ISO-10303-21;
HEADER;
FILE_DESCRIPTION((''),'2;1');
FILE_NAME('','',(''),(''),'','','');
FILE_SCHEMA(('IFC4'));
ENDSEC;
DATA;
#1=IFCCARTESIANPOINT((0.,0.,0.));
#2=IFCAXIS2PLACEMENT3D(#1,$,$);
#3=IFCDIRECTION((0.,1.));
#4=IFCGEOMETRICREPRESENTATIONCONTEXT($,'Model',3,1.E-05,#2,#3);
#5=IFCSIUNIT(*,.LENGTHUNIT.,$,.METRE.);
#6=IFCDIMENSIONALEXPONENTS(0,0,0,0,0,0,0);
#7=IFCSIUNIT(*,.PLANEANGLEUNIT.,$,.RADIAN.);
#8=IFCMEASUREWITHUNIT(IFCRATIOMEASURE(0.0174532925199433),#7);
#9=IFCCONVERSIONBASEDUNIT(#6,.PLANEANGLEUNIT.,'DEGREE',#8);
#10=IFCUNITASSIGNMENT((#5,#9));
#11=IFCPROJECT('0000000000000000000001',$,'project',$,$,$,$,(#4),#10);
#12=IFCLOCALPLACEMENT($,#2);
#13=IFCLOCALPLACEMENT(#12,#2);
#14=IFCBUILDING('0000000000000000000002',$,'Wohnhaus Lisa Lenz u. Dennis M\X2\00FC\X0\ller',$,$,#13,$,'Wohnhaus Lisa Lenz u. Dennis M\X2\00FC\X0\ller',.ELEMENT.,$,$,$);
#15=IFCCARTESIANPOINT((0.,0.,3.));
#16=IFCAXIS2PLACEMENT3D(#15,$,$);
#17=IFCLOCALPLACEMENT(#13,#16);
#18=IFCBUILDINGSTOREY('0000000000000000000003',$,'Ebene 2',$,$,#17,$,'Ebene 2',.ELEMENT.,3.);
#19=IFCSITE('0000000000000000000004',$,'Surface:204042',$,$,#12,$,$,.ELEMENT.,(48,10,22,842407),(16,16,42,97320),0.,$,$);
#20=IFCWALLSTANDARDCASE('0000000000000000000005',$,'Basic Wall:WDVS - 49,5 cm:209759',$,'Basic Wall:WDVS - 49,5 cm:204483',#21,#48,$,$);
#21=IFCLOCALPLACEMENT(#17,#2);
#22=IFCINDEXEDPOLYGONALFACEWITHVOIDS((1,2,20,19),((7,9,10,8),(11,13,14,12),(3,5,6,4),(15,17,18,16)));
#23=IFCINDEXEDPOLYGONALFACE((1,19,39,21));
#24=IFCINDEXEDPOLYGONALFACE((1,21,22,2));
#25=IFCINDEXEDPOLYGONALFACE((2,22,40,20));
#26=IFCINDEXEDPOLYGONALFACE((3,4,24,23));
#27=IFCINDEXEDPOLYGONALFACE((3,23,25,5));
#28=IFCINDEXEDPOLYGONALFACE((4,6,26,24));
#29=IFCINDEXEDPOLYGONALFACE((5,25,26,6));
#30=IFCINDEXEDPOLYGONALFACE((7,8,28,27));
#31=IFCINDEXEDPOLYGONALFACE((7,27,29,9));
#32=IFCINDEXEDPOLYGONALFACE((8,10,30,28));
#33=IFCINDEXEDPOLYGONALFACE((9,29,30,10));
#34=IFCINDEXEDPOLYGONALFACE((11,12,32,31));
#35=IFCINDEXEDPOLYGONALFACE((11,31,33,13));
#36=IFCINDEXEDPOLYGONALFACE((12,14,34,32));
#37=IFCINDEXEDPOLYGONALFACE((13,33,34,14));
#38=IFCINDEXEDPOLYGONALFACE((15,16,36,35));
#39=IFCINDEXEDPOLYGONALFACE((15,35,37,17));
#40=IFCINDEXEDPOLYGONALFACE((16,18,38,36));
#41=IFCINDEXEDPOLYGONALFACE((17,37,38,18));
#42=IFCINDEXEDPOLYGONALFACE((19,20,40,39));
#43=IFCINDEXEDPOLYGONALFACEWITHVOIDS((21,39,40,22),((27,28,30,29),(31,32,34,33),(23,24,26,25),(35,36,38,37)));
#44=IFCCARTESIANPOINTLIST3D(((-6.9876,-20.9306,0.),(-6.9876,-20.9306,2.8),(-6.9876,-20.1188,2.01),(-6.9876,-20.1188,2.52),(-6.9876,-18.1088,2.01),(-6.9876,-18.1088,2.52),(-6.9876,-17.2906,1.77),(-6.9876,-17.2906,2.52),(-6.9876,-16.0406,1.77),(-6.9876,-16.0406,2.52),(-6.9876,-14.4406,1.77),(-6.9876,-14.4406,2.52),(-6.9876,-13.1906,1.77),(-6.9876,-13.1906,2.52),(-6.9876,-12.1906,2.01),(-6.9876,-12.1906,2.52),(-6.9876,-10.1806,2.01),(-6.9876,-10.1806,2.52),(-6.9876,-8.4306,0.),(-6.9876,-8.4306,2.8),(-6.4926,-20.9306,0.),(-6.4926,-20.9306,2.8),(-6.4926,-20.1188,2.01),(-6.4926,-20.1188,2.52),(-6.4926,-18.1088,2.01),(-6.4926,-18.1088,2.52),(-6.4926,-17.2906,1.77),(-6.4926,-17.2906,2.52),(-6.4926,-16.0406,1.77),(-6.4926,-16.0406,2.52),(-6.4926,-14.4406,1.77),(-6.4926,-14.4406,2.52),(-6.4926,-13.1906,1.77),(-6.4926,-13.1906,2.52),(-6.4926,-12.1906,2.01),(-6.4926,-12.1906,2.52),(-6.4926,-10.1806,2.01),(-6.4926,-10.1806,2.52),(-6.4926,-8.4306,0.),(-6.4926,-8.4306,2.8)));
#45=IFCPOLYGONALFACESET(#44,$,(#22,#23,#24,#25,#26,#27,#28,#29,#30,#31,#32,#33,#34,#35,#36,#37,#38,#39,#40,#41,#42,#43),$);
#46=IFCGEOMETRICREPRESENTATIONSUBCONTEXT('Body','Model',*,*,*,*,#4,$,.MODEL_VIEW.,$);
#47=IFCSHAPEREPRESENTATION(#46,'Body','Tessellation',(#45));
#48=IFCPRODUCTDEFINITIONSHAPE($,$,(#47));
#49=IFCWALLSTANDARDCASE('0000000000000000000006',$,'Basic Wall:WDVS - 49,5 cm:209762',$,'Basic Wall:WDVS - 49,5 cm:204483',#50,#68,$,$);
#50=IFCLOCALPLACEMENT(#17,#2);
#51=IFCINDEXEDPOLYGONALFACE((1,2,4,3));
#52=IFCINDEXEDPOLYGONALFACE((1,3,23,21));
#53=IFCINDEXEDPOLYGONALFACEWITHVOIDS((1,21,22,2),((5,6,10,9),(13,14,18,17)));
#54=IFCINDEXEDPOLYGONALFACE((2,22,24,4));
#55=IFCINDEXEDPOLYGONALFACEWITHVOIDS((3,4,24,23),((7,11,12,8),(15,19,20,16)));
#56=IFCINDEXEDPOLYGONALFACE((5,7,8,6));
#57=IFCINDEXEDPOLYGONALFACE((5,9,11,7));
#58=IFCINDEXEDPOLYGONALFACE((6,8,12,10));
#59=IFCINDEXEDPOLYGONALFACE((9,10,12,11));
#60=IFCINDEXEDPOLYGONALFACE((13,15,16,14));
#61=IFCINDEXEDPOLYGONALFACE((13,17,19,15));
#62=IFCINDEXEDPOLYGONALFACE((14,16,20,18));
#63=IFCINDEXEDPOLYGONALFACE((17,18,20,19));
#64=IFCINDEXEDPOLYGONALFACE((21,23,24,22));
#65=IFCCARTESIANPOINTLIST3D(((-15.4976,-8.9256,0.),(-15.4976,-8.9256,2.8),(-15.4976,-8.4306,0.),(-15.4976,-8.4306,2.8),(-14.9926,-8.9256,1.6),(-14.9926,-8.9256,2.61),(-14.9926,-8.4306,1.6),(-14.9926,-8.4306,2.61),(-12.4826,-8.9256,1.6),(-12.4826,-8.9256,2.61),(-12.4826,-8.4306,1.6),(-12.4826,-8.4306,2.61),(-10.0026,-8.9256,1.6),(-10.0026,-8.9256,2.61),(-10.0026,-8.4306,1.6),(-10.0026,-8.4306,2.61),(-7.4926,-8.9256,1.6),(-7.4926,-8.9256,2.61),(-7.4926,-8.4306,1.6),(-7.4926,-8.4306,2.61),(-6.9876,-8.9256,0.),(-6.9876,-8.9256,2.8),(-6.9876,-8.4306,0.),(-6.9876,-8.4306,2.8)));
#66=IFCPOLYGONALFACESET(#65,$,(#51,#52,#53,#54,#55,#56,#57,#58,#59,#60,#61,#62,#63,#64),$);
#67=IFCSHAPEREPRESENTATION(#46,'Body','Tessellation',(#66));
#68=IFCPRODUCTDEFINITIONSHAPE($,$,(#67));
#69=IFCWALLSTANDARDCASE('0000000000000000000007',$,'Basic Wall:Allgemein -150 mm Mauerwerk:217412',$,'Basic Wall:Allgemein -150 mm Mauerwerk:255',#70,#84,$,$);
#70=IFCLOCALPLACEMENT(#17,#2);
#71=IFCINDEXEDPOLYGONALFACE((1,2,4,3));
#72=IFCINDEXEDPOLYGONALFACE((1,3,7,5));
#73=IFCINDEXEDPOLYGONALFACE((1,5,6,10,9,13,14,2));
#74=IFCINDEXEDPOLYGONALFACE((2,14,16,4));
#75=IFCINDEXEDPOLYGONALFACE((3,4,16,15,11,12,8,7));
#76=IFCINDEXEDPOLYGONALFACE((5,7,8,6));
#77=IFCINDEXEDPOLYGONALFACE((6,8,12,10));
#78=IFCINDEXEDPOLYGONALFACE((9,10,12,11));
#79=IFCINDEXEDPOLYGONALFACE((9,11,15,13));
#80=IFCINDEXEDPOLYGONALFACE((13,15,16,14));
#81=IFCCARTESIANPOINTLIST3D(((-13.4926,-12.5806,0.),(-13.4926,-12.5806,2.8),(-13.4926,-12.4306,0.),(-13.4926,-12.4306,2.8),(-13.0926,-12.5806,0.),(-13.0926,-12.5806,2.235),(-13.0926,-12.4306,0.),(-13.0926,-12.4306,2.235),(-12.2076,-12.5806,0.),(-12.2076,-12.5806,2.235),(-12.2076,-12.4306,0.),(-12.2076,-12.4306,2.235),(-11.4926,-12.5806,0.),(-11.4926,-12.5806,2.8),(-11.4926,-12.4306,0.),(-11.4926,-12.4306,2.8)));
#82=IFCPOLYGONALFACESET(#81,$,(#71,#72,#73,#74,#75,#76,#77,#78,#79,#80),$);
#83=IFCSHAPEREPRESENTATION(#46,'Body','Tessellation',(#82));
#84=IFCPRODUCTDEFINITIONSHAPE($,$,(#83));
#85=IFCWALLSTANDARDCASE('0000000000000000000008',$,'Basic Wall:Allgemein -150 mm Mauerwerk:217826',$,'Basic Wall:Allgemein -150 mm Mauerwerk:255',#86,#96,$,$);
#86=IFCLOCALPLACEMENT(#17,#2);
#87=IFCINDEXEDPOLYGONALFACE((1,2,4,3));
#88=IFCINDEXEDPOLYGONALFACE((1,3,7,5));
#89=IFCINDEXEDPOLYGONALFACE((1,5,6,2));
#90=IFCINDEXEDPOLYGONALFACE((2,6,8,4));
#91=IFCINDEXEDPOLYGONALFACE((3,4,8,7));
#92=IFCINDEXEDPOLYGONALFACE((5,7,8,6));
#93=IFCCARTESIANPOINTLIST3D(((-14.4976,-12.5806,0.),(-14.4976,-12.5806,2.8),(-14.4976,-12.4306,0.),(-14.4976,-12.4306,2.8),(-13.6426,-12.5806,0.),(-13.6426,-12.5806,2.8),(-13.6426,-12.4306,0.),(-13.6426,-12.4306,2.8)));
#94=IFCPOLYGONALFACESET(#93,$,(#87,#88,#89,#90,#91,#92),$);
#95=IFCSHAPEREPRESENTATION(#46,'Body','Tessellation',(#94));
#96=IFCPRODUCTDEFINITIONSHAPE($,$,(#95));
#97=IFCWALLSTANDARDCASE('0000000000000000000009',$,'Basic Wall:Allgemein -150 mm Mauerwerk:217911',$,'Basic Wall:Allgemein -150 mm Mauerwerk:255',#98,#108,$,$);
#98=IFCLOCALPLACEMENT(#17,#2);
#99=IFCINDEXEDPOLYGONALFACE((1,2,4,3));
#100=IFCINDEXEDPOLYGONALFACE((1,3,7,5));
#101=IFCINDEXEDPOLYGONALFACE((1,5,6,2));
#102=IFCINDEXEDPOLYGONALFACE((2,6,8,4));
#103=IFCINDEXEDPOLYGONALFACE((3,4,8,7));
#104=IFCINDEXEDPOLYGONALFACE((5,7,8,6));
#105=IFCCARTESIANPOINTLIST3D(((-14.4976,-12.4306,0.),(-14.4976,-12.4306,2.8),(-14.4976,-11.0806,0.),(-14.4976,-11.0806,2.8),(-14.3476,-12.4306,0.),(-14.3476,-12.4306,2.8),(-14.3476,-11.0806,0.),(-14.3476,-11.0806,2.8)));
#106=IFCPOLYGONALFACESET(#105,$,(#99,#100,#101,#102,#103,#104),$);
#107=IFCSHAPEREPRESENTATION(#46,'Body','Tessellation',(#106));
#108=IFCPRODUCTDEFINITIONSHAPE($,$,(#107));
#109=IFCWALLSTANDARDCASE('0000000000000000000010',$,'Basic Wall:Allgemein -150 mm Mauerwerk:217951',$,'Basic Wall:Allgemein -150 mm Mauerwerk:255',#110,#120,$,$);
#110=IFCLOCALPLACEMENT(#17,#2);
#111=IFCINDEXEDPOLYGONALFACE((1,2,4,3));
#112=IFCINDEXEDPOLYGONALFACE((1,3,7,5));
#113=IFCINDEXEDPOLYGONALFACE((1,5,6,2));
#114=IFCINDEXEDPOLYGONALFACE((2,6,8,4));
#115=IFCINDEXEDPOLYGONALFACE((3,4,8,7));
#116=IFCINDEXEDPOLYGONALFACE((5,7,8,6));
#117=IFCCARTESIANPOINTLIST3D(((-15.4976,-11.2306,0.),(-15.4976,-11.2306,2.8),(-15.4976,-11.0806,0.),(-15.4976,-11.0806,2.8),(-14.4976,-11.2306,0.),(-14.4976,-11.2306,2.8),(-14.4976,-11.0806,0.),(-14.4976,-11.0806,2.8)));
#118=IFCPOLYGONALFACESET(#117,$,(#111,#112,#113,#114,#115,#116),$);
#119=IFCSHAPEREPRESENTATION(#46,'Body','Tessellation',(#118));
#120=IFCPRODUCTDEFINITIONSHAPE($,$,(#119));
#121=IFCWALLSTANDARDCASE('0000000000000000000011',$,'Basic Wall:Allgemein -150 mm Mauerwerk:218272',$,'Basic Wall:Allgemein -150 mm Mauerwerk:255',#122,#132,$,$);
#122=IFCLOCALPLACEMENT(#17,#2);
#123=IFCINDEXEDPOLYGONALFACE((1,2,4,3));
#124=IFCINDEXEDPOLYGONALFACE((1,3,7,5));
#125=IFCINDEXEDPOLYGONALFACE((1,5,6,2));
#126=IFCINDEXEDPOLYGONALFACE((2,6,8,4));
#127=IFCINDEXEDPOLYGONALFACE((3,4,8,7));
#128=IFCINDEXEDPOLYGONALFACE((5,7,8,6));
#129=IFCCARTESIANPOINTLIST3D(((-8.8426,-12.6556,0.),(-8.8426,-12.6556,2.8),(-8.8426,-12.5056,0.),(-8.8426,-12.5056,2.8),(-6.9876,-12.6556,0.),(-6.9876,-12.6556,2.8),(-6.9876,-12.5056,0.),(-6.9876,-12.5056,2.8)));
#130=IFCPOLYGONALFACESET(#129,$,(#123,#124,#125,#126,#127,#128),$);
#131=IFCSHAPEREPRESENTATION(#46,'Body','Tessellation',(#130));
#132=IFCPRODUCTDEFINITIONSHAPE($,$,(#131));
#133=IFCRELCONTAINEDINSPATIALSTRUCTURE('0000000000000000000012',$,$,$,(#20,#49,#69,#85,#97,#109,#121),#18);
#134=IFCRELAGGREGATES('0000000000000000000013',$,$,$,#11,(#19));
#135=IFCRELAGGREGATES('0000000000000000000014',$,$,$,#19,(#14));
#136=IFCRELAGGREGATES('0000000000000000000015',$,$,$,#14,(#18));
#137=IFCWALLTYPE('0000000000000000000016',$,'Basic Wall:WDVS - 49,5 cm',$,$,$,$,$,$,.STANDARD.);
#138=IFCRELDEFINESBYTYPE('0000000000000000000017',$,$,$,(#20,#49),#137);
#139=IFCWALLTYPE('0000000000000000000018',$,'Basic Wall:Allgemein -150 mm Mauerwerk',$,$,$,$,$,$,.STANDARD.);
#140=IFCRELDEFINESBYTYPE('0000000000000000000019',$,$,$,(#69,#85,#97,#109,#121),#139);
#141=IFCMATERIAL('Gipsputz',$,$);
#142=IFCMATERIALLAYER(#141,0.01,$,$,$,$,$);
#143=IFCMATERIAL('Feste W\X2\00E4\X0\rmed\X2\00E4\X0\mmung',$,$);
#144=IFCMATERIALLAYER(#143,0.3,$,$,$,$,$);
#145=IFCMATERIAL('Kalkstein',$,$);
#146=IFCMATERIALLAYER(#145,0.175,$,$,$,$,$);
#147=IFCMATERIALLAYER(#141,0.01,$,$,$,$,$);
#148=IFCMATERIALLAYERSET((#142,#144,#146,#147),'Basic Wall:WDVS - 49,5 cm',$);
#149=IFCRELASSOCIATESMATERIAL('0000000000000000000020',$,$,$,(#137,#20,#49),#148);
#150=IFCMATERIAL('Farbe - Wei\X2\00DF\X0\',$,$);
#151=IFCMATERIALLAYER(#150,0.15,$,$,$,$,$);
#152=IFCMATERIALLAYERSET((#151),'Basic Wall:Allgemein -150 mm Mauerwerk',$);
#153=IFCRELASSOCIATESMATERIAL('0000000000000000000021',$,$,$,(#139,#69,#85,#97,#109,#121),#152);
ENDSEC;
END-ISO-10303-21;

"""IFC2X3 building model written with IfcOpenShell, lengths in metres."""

from ifc_helpers import new_model, entity, si_unit, converted_unit, direction, frame, frame_2d, origin, place, context, subcontext, project, spatial, polyline, rectangle, extrude, clip, bounded_halfspace, material, layer, layer_set, layer_usage, type_object, element, save


model = new_model("IFC2X3")

# Units and contexts
model_context = context("Model", 3, precision=1e-05, world=origin(), true_north=direction((0.0, 1.0)))
body_context = subcontext(model_context, "Body", "Model", "MODEL_VIEW")
ifc_project = project(units=[si_unit("LENGTHUNIT", "METRE"), converted_unit("PLANEANGLEUNIT", "DEGREE", entity("IfcRatioMeasure", 0.0174532925199433), si_unit("PLANEANGLEUNIT", "RADIAN"), dimensions=[0, 0, 0, 0, 0, 0, 0])], contexts=[model_context])

# Site, building, storey
site_placement = place(None, origin())
site = spatial("IfcSite", under=ifc_project, at=site_placement, Name="Surface:204042", CompositionType="ELEMENT", RefLatitude=(48, 10, 22, 842407), RefLongitude=(16, 16, 42, 97320), RefElevation=0.0)
building_placement = place(site_placement, origin())
building = spatial("IfcBuilding", under=site, at=building_placement, Name="Wohnhaus Lisa Lenz u. Dennis Müller", LongName="Wohnhaus Lisa Lenz u. Dennis Müller", CompositionType="ELEMENT")
storey_placement = place(building_placement, frame((0.0, 0.0, 3.0)))
storey = spatial("IfcBuildingStorey", under=building, at=storey_placement, Name="Ebene 2", LongName="Ebene 2", CompositionType="ELEMENT", Elevation=3.0)

# Walls, openings
ifc_material_1 = material(Name="Gipsputz")
ifc_layer_1 = layer(ifc_material_1, 0.01)
ifc_material_2 = material(Name="Feste Wärmedämmung")
ifc_layer_2 = layer(ifc_material_2, 0.3)
ifc_material_3 = material(Name="Kalkstein")
ifc_layer_3 = layer(ifc_material_3, 0.175)
ifc_layer_4 = layer(ifc_material_1, 0.01)
ifc_layer_set_1 = layer_set([ifc_layer_1, ifc_layer_2, ifc_layer_3, ifc_layer_4], Name="Basic Wall:WDVS - 49,5 cm")
ifc_layer_usage_1 = layer_usage(ifc_layer_set_1, "AXIS2", "NEGATIVE", 0.2475)
wall_type_1 = type_object("IfcWallType", Name="Basic Wall:WDVS - 49,5 cm", PredefinedType="STANDARD", material=ifc_layer_set_1)
wall_1_placement = place(storey_placement, frame((-6.7401, -8.4306, 0.0), z_axis=(0.0, 0.0, 1.0), x_axis=(0.0, -1.0, 0.0)))
wall_1 = element("IfcWallStandardCase", 1, at=wall_1_placement, inside=storey, type_object=wall_type_1, material=ifc_layer_usage_1, Name="Basic Wall:WDVS - 49,5 cm:209759", ObjectType="Basic Wall:WDVS - 49,5 cm:204483", context=body_context, shape_type="Clipping", body=[
    clip(extrude(rectangle(XDim=12.5, YDim=0.495, at=frame_2d((6.25, 0.0), x_axis=(-1.0, 0.0))), origin(), (0.0, 0.0, 1.0), 2.8), bounded_halfspace(frame((0.0, -0.2475, 2.8), z_axis=(0.0, 0.0, -1.0), x_axis=(1.0, 0.0, 0.0)), True, frame((0.0, -0.2475, 2.8)), polyline([(0.0, 0.0), (0.495, 0.0), (4.075, 0.0), (4.225, 0.0), (9.05, 0.0), (9.178, 0.0), (12.005, 0.0), (12.5, 0.0), (12.5, 0.495), (0.0, 0.495), (0.0, 0.0)]))),
])
opening_1_placement = place(wall_1_placement, frame((8.86, 0.2475, 1.77)))
element("IfcOpeningElement", 2, at=opening_1_placement, cuts=wall_1, ObjectType="Opening", context=body_context, shape_type="SweptSolid", body=[
    extrude(rectangle(XDim=0.75, YDim=1.25, at=frame_2d((0.375, 0.625), x_axis=(1.0, 0.0))), frame((0.0, 0.0, 0.0), z_axis=(0.0, -1.0, 0.0), x_axis=(0.0, 0.0, 1.0)), (0.0, 0.0, 1.0), 0.495),
])
opening_2_placement = place(wall_1_placement, frame((6.01, 0.2475, 1.77)))
element("IfcOpeningElement", 3, at=opening_2_placement, cuts=wall_1, ObjectType="Opening", context=body_context, shape_type="SweptSolid", body=[
    extrude(rectangle(XDim=0.75, YDim=1.25, at=frame_2d((0.375, 0.625), x_axis=(1.0, 0.0))), frame((0.0, 0.0, 0.0), z_axis=(0.0, -1.0, 0.0), x_axis=(0.0, 0.0, 1.0)), (0.0, 0.0, 1.0), 0.495),
])
opening_3_placement = place(wall_1_placement, frame((3.76, 0.2475, 2.01)))
element("IfcOpeningElement", 4, at=opening_3_placement, cuts=wall_1, ObjectType="Opening", context=body_context, shape_type="SweptSolid", body=[
    extrude(rectangle(XDim=0.51, YDim=2.01, at=frame_2d((0.255, 1.005), x_axis=(1.0, 0.0))), frame((0.0, 0.0, 0.0), z_axis=(0.0, -1.0, 0.0), x_axis=(0.0, 0.0, 1.0)), (0.0, 0.0, 1.0), 0.495),
])
opening_4_placement = place(wall_1_placement, frame((11.6883, 0.2475, 2.01)))
element("IfcOpeningElement", 5, at=opening_4_placement, cuts=wall_1, ObjectType="Opening", context=body_context, shape_type="SweptSolid", body=[
    extrude(rectangle(XDim=0.51, YDim=2.01, at=frame_2d((0.255, 1.005), x_axis=(1.0, 0.0))), frame((0.0, 0.0, 0.0), z_axis=(0.0, -1.0, 0.0), x_axis=(0.0, 0.0, 1.0)), (0.0, 0.0, 1.0), 0.495),
])
ifc_layer_usage_2 = layer_usage(ifc_layer_set_1, "AXIS2", "NEGATIVE", 0.2475)
wall_2_placement = place(storey_placement, frame((-15.4976, -8.6781, 0.0)))
wall_2 = element("IfcWallStandardCase", 6, at=wall_2_placement, inside=storey, type_object=wall_type_1, material=ifc_layer_usage_2, Name="Basic Wall:WDVS - 49,5 cm:209762", ObjectType="Basic Wall:WDVS - 49,5 cm:204483", context=body_context, shape_type="Clipping", body=[
    clip(extrude(rectangle(XDim=8.51, YDim=0.495, at=frame_2d((4.255, 0.0), x_axis=(-1.0, 0.0))), origin(), (0.0, 0.0, 1.0), 2.8), bounded_halfspace(frame((0.0, -0.2475, 2.8), z_axis=(0.0, 0.0, -1.0), x_axis=(0.0, -1.0, 0.0)), True, frame((0.0, -0.2475, 2.8)), polyline([(0.0, 0.0), (4.005, 0.0), (4.505, 0.0), (8.51, 0.0), (8.51, 0.495), (0.0, 0.495), (0.0, 0.0)]))),
])
opening_5_placement = place(wall_2_placement, frame((8.005, 0.2475, 1.6)))
element("IfcOpeningElement", 7, at=opening_5_placement, cuts=wall_2, ObjectType="Opening", context=body_context, shape_type="SweptSolid", body=[
    extrude(rectangle(XDim=1.01, YDim=2.51, at=frame_2d((0.505, 1.255), x_axis=(1.0, 0.0))), frame((0.0, 0.0, 0.0), z_axis=(0.0, -1.0, 0.0), x_axis=(0.0, 0.0, 1.0)), (0.0, 0.0, 1.0), 0.495),
])
opening_6_placement = place(wall_2_placement, frame((3.015, 0.2475, 1.6)))
element("IfcOpeningElement", 8, at=opening_6_placement, cuts=wall_2, ObjectType="Opening", context=body_context, shape_type="SweptSolid", body=[
    extrude(rectangle(XDim=1.01, YDim=2.51, at=frame_2d((0.505, 1.255), x_axis=(1.0, 0.0))), frame((0.0, 0.0, 0.0), z_axis=(0.0, -1.0, 0.0), x_axis=(0.0, 0.0, 1.0)), (0.0, 0.0, 1.0), 0.495),
])

# Wall, opening
ifc_material_4 = material(Name="Farbe - Weiß")
ifc_layer_5 = layer(ifc_material_4, 0.15)
ifc_layer_set_2 = layer_set([ifc_layer_5], Name="Basic Wall:Allgemein -150 mm Mauerwerk")
ifc_layer_usage_3 = layer_usage(ifc_layer_set_2, "AXIS2", "NEGATIVE", 0.075)
wall_type_2 = type_object("IfcWallType", Name="Basic Wall:Allgemein -150 mm Mauerwerk", PredefinedType="STANDARD", material=ifc_layer_set_2)
wall_3_placement = place(storey_placement, frame((-13.4926, -12.5056, 0.0)))
wall_3 = element("IfcWallStandardCase", 9, at=wall_3_placement, inside=storey, type_object=wall_type_2, material=ifc_layer_usage_3, Name="Basic Wall:Allgemein -150 mm Mauerwerk:217412", ObjectType="Basic Wall:Allgemein -150 mm Mauerwerk:255", context=body_context, shape_type="Clipping", body=[
    clip(extrude(rectangle(XDim=2.0, YDim=0.15, at=frame_2d((1.0, 0.0), x_axis=(-1.0, 0.0))), origin(), (0.0, 0.0, 1.0), 2.8), bounded_halfspace(frame((0.0, -0.075, 2.8), z_axis=(0.0, 0.0, -1.0), x_axis=(0.0, -1.0, 0.0)), True, frame((0.0, -0.075, 2.8)), polyline([(0.0, 0.0), (2.0, 0.0), (2.0, 0.15), (0.0, 0.15), (0.0, 0.0)]))),
])
opening_7_placement = place(wall_3_placement, frame((0.4, -0.075, 0.0)))
element("IfcOpeningElement", 10, at=opening_7_placement, cuts=wall_3, ObjectType="Opening", context=body_context, shape_type="SweptSolid", body=[
    extrude(rectangle(XDim=2.235, YDim=0.885, at=frame_2d((1.1175, 0.4425), x_axis=(1.0, 0.0))), frame((0.0, 0.0, 0.0), z_axis=(0.0, 1.0, 0.0), x_axis=(0.0, 0.0, 1.0)), (0.0, 0.0, 1.0), 0.15),
])

# Walls
ifc_layer_usage_4 = layer_usage(ifc_layer_set_2, "AXIS2", "NEGATIVE", 0.075)
wall_4_placement = place(storey_placement, frame((-13.6426, -12.5056, 0.0), z_axis=(0.0, 0.0, 1.0), x_axis=(-1.0, 0.0, 0.0)))
element("IfcWallStandardCase", 11, at=wall_4_placement, inside=storey, type_object=wall_type_2, material=ifc_layer_usage_4, Name="Basic Wall:Allgemein -150 mm Mauerwerk:217826", ObjectType="Basic Wall:Allgemein -150 mm Mauerwerk:255", context=body_context, shape_type="Clipping", body=[
    clip(extrude(rectangle(XDim=0.855, YDim=0.15, at=frame_2d((0.4275, 0.0), x_axis=(-1.0, 0.0))), origin(), (0.0, 0.0, 1.0), 2.8), bounded_halfspace(frame((0.0, -0.075, 2.8), z_axis=(0.0, 0.0, -1.0), x_axis=(0.0, 1.0, 0.0)), True, frame((0.0, -0.075, 2.8)), polyline([(0.0, 0.0), (0.705, 0.0), (0.855, 0.0), (0.855, 0.15), (0.0, 0.15), (0.0, 0.0)]))),
])
ifc_layer_usage_5 = layer_usage(ifc_layer_set_2, "AXIS2", "NEGATIVE", 0.075)
wall_5_placement = place(storey_placement, frame((-14.4226, -12.4306, 0.0), z_axis=(0.0, 0.0, 1.0), x_axis=(0.0, 1.0, 0.0)))
element("IfcWallStandardCase", 12, at=wall_5_placement, inside=storey, type_object=wall_type_2, material=ifc_layer_usage_5, Name="Basic Wall:Allgemein -150 mm Mauerwerk:217911", ObjectType="Basic Wall:Allgemein -150 mm Mauerwerk:255", context=body_context, shape_type="Clipping", body=[
    clip(extrude(rectangle(XDim=1.35, YDim=0.15, at=frame_2d((0.675, 0.0), x_axis=(-1.0, 0.0))), origin(), (0.0, 0.0, 1.0), 2.8), bounded_halfspace(frame((0.0, -0.075, 2.8), z_axis=(0.0, 0.0, -1.0), x_axis=(-1.0, 0.0, 0.0)), True, frame((0.0, -0.075, 2.8)), polyline([(0.0, 0.0), (1.35, 0.0), (1.35, 0.15), (1.2, 0.15), (0.0, 0.15), (0.0, 0.0)]))),
])
ifc_layer_usage_6 = layer_usage(ifc_layer_set_2, "AXIS2", "NEGATIVE", 0.075)
wall_6_placement = place(storey_placement, frame((-14.4976, -11.1556, 0.0), z_axis=(0.0, 0.0, 1.0), x_axis=(-1.0, 0.0, 0.0)))
element("IfcWallStandardCase", 13, at=wall_6_placement, inside=storey, type_object=wall_type_2, material=ifc_layer_usage_6, Name="Basic Wall:Allgemein -150 mm Mauerwerk:217951", ObjectType="Basic Wall:Allgemein -150 mm Mauerwerk:255", context=body_context, shape_type="Clipping", body=[
    clip(extrude(rectangle(XDim=1.0, YDim=0.15, at=frame_2d((0.5, 0.0), x_axis=(-1.0, 0.0))), origin(), (0.0, 0.0, 1.0), 2.8), bounded_halfspace(frame((0.0, -0.075, 2.8), z_axis=(0.0, 0.0, -1.0), x_axis=(0.0, 1.0, 0.0)), True, frame((0.0, -0.075, 2.8)), polyline([(0.0, 0.0), (1.0, 0.0), (1.0, 0.15), (0.0, 0.15), (0.0, 0.0)]))),
])
ifc_layer_usage_7 = layer_usage(ifc_layer_set_2, "AXIS2", "POSITIVE", -0.075)
wall_7_placement = place(storey_placement, frame((-8.8426, -12.5806, 0.0)))
element("IfcWallStandardCase", 14, at=wall_7_placement, inside=storey, type_object=wall_type_2, material=ifc_layer_usage_7, Name="Basic Wall:Allgemein -150 mm Mauerwerk:218272", ObjectType="Basic Wall:Allgemein -150 mm Mauerwerk:255", context=body_context, shape_type="Clipping", body=[
    clip(extrude(rectangle(XDim=1.855, YDim=0.15, at=frame_2d((0.9275, 0.0), x_axis=(-1.0, 0.0))), origin(), (0.0, 0.0, 1.0), 2.8), bounded_halfspace(frame((0.0, -0.075, 2.8), z_axis=(0.0, 0.0, -1.0), x_axis=(0.0, -1.0, 0.0)), True, frame((0.0, -0.075, 2.8)), polyline([(0.0, 0.0), (0.8525, 0.0), (1.0025, 0.0), (1.855, 0.0), (1.855, 0.15), (0.0, 0.15), (0.0, 0.0)]))),
])

save(model, "model.ifc")
